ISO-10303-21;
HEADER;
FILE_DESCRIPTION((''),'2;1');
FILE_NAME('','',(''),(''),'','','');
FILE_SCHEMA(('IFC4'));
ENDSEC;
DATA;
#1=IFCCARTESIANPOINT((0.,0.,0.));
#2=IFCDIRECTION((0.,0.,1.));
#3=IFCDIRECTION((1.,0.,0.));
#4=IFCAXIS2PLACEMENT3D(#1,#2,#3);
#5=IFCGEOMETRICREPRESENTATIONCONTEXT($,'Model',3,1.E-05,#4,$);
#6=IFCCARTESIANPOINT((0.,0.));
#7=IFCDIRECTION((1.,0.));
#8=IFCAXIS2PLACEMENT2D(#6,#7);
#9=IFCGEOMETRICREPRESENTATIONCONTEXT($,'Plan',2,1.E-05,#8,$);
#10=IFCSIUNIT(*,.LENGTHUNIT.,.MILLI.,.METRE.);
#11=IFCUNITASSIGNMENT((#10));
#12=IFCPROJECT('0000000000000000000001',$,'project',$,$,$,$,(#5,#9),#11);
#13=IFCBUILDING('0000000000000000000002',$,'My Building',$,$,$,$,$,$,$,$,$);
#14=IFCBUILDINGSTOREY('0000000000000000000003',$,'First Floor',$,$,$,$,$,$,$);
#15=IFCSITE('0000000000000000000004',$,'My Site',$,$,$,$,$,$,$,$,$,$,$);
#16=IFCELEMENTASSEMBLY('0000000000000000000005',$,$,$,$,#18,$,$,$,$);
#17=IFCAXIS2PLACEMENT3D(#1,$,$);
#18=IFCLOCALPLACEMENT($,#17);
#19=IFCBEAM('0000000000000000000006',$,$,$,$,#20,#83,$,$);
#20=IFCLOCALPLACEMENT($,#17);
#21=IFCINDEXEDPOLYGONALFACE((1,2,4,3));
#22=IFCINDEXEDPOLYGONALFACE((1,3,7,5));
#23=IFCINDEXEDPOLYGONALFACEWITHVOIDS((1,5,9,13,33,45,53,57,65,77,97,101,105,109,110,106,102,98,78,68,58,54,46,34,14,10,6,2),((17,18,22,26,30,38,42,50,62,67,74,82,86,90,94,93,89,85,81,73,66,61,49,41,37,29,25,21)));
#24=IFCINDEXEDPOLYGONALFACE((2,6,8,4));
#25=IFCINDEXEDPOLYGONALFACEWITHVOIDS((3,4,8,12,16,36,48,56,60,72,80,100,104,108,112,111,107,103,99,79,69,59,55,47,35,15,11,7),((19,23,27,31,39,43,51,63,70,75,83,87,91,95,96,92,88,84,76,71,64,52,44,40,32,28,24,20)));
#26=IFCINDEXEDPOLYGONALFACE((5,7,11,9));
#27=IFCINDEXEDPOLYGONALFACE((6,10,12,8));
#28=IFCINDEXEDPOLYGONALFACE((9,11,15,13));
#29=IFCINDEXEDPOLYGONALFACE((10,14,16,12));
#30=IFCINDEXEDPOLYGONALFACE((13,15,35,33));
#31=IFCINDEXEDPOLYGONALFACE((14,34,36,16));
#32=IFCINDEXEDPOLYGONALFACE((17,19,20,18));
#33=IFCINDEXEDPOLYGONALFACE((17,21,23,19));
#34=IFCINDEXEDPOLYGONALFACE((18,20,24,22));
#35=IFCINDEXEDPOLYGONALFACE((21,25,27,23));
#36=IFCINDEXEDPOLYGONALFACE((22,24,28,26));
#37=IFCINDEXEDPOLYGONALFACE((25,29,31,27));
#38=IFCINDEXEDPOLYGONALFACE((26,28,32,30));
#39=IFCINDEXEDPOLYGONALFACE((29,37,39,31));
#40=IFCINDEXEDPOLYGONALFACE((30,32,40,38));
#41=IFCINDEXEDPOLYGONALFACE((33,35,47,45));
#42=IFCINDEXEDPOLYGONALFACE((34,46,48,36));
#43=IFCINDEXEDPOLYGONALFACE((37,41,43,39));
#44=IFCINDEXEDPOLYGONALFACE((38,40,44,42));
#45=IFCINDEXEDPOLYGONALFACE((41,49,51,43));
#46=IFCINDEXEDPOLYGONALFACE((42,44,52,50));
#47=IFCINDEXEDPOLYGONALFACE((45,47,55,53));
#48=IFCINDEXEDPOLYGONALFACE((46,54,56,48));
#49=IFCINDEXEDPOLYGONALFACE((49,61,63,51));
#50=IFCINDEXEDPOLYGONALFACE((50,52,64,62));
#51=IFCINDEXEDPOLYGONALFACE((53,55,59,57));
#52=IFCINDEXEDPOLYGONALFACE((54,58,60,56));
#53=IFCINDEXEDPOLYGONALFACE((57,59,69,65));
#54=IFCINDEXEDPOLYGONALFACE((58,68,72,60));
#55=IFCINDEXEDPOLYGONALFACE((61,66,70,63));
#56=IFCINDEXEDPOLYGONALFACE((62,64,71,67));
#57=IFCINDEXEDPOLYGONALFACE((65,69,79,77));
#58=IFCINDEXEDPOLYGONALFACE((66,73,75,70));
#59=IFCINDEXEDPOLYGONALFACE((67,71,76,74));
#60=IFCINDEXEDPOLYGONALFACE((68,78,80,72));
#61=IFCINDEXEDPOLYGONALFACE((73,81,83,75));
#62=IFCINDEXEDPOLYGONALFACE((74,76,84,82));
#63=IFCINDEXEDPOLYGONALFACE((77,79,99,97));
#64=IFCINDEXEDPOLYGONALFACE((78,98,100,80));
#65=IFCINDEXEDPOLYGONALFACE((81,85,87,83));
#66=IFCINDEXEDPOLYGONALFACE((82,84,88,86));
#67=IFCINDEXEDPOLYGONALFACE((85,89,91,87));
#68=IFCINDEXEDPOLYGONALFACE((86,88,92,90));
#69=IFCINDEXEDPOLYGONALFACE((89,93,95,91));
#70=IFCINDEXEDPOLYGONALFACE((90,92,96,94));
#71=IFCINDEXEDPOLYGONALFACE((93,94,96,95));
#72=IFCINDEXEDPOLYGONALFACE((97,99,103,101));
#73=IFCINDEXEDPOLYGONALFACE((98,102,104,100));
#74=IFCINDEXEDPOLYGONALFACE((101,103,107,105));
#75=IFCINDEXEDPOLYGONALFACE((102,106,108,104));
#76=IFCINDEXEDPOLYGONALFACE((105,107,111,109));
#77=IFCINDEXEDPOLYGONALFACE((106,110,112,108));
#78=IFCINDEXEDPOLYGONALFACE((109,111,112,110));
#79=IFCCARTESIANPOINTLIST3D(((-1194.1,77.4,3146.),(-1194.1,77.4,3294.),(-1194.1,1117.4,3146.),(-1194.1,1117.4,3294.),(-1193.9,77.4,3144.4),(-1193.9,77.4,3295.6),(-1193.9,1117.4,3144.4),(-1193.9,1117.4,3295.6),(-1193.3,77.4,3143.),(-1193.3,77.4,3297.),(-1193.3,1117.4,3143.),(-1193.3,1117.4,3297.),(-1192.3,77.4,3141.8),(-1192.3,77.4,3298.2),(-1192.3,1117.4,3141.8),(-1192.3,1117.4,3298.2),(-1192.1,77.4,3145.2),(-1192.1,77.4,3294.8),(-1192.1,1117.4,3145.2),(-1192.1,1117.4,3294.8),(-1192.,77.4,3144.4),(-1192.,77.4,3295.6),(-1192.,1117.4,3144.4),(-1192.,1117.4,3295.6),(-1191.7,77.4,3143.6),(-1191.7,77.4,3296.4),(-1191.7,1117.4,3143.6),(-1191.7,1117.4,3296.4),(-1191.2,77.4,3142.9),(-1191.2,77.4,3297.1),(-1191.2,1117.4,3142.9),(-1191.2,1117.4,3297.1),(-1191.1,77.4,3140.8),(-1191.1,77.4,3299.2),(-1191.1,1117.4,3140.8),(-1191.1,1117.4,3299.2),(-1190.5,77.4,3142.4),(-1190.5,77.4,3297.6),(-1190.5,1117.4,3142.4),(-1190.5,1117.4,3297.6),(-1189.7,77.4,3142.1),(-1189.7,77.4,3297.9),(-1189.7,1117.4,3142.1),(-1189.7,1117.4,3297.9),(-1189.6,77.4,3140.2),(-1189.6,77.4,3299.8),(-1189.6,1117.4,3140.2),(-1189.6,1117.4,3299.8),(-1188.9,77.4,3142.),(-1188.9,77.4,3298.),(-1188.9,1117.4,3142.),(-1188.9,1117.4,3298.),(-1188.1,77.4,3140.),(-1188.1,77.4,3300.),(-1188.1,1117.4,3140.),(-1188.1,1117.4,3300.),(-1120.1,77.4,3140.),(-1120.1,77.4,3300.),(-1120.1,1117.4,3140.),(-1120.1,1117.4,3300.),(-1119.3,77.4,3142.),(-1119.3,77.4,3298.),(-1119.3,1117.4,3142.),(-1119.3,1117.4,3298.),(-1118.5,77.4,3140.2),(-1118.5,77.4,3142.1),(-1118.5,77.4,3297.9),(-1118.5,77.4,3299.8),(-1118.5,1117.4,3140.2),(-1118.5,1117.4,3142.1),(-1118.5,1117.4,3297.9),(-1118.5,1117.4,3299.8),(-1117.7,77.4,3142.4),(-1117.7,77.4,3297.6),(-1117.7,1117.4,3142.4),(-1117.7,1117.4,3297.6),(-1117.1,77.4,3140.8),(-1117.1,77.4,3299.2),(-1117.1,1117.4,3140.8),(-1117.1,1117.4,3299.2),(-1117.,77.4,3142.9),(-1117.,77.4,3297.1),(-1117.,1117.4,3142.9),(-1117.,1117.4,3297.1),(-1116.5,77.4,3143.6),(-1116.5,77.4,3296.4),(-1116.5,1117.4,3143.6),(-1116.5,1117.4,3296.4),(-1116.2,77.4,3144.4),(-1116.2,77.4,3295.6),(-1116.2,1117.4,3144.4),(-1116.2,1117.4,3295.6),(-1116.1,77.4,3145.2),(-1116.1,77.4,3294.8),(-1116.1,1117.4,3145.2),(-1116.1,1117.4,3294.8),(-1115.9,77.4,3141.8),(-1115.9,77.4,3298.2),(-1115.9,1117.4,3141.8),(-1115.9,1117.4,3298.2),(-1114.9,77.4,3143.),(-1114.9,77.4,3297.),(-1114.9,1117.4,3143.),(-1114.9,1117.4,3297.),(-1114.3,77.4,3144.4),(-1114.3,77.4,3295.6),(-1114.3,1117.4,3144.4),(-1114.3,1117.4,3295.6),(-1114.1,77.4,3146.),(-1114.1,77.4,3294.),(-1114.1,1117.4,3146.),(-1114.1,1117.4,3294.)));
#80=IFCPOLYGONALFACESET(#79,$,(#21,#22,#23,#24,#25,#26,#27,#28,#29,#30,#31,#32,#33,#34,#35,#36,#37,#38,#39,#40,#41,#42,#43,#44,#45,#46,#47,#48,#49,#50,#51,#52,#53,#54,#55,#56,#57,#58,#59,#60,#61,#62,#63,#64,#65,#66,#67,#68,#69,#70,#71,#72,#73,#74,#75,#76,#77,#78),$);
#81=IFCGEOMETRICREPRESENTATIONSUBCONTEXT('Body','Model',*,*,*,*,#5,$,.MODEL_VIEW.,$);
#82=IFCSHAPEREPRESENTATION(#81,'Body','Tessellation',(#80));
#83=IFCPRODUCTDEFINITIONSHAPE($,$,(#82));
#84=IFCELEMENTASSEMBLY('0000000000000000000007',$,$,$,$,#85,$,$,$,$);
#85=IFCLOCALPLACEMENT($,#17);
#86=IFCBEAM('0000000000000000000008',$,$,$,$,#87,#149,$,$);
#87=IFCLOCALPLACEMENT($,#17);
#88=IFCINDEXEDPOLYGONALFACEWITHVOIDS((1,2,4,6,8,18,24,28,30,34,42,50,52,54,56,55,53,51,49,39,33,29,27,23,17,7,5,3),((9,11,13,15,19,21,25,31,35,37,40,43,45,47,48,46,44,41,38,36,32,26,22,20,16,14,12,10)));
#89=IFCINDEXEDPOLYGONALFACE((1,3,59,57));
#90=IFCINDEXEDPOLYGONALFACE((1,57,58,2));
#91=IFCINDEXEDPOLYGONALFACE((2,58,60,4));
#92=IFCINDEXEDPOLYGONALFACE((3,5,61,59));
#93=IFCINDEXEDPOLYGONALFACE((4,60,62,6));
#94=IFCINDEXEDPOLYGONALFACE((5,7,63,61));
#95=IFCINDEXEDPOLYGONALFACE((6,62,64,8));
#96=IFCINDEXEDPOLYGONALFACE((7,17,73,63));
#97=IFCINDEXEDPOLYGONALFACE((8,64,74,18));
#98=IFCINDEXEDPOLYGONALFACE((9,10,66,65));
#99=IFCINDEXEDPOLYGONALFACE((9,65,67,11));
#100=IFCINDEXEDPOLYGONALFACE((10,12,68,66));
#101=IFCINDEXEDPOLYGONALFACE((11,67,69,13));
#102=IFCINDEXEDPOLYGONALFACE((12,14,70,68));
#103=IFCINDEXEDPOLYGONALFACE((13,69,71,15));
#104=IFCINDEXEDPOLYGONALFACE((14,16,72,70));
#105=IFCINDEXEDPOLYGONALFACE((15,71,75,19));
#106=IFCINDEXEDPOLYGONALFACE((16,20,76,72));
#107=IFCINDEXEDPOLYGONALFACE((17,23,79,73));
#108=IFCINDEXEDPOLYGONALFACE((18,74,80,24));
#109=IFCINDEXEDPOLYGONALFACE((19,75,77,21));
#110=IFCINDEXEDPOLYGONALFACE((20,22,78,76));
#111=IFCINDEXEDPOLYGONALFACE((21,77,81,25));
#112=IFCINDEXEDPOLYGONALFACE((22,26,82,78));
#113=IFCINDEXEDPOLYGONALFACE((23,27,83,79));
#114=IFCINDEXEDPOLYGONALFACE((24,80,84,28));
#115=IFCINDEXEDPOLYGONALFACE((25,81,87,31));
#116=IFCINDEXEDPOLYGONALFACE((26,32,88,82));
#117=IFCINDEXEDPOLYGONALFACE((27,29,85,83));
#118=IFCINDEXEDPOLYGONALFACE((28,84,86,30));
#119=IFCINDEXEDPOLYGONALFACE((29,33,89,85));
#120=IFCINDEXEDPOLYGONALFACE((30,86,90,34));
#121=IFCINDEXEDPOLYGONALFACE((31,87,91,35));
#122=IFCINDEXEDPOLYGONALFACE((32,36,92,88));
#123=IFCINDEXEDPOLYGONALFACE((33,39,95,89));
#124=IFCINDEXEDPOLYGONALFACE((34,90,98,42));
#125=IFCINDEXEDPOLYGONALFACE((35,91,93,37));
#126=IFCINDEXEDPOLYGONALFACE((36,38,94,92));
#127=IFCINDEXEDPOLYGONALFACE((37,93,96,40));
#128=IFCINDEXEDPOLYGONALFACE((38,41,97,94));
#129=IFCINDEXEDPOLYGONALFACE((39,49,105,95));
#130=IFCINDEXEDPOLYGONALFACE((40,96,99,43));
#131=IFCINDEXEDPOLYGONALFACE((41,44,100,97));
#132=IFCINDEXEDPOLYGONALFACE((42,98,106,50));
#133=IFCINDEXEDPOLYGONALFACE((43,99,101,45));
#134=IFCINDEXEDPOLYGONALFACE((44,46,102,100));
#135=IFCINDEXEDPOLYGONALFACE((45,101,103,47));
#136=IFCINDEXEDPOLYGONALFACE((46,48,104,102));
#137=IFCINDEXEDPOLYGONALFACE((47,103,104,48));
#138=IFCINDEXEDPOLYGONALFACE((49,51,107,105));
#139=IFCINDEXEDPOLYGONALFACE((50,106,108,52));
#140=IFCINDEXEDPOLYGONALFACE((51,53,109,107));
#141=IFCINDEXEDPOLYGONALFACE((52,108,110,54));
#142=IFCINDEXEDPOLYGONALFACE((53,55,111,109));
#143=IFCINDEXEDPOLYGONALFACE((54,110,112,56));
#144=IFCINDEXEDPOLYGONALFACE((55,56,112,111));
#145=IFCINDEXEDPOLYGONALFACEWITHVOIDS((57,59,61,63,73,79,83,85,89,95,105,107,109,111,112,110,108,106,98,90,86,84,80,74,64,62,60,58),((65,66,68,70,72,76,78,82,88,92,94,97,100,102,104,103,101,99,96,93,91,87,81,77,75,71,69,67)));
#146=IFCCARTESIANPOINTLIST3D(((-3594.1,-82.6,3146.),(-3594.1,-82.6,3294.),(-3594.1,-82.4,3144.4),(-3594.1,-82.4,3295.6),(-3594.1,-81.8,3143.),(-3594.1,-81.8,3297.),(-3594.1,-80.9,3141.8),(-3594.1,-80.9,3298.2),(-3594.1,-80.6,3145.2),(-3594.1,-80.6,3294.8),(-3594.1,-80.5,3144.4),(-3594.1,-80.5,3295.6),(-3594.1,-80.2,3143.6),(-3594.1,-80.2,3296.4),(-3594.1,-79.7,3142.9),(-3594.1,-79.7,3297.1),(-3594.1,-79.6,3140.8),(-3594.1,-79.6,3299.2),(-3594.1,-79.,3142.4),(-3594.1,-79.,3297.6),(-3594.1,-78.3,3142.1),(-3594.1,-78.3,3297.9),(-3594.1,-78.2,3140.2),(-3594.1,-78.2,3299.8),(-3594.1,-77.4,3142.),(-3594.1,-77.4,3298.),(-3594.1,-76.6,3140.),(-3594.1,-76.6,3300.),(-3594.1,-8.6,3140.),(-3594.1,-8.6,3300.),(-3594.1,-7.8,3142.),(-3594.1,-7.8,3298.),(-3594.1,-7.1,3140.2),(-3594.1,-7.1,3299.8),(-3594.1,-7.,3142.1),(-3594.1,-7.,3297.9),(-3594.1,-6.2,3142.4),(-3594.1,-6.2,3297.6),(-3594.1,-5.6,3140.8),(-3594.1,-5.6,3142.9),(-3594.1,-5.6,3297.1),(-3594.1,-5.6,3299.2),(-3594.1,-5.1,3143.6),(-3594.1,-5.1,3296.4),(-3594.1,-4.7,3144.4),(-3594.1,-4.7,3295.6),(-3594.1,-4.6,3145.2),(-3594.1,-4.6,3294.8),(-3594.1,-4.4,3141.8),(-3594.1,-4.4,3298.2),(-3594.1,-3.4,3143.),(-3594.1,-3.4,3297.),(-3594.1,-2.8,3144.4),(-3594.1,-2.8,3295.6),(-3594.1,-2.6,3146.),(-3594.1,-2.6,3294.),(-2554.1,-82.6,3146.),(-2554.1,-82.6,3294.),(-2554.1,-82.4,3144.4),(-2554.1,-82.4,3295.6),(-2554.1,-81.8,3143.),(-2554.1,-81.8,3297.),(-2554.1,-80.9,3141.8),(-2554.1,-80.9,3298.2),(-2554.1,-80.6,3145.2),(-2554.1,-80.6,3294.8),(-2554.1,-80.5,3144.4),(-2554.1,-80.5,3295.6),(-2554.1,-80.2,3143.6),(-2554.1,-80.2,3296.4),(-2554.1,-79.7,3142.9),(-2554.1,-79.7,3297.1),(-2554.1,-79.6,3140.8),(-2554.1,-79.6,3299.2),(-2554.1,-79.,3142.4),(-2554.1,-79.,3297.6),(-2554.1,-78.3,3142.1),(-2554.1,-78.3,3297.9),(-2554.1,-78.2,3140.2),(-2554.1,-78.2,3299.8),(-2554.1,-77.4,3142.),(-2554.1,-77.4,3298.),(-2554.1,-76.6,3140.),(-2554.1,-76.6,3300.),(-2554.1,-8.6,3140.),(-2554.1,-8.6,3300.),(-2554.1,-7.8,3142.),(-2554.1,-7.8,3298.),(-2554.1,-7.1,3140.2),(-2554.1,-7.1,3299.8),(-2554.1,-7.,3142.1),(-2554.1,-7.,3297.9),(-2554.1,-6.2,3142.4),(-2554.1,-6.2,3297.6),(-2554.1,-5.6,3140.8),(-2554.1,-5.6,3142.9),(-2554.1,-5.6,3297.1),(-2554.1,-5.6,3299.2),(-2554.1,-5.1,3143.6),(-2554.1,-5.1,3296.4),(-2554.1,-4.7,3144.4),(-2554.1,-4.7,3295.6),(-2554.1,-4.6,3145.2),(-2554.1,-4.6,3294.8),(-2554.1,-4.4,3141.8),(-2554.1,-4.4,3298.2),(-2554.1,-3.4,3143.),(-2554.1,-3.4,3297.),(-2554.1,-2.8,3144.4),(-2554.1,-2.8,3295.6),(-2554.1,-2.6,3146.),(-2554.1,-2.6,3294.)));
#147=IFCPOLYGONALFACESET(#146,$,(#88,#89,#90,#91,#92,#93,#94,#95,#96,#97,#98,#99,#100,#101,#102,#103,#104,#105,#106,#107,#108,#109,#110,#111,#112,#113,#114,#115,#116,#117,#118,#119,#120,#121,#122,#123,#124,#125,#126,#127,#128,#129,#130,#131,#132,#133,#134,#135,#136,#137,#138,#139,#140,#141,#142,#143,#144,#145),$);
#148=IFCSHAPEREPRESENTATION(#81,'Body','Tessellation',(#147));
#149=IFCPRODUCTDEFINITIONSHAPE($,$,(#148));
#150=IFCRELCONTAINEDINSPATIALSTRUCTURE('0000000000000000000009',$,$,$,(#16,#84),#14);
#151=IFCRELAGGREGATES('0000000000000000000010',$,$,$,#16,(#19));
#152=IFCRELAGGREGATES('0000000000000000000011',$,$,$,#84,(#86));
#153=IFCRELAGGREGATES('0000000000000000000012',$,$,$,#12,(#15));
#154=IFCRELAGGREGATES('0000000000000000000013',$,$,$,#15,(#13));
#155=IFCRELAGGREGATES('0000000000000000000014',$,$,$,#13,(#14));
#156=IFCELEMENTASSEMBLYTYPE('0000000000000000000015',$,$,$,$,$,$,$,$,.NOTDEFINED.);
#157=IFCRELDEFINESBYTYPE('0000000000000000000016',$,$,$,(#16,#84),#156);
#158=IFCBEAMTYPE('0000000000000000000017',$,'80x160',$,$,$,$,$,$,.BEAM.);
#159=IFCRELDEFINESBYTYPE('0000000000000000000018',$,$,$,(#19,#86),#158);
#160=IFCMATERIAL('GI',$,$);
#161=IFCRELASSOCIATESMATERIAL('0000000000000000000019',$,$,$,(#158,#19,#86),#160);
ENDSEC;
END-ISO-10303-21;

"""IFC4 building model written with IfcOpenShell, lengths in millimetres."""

from ifc_helpers import new_model, si_unit, frame, origin_with_axes, origin_2d_with_axis, place, context, subcontext, project, spatial, hollow_rectangle, extrude, material, material_profile, profile_set, profile_usage, type_object, element, aggregate, save


model = new_model("IFC4")

# Units and contexts
model_context = context("Model", 3, precision=1e-05, world=origin_with_axes())
plan_context = context("Plan", 2, precision=1e-05, world=origin_2d_with_axis())
body_context = subcontext(model_context, "Body", "Model", "MODEL_VIEW")
ifc_project = project(units=[si_unit("LENGTHUNIT", "METRE", prefix="MILLI")], contexts=[model_context, plan_context])

# Site, building, storey
site = spatial("IfcSite", under=ifc_project, Name="My Site")
building = spatial("IfcBuilding", under=site, Name="My Building")
storey = spatial("IfcBuildingStorey", under=building, Name="First Floor")

# Element assemblies, beams
element_assembly_type = type_object("IfcElementAssemblyType", PredefinedType="NOTDEFINED")
ifc_material = material(Name="GI")
ifc_material_profile = material_profile(ifc_material, hollow_rectangle(XDim=80.0, YDim=160.0, WallThickness=2.0, InnerFilletRadius=3.2, OuterFilletRadius=6.0))
ifc_profile_set = profile_set([ifc_material_profile], Name="80x160 GI Rectangular Hollow")
beam_type = type_object("IfcBeamType", Name="80x160", PredefinedType="BEAM", material=ifc_profile_set)
assembly_1_placement = place(None, frame((-1154.1, -2.6, 3220.0), z_axis=(0.0, 1.0, 0.0), x_axis=(1.0, 0.0, 0.0)))
assembly_1 = element("IfcElementAssembly", 1, at=assembly_1_placement, inside=storey, type_object=element_assembly_type)
ifc_profile_usage_1 = profile_usage(ifc_profile_set)
beam_1_placement = place(assembly_1_placement, frame((0.0, 0.0, 80.0), z_axis=(0.0, 0.0, 1.0), x_axis=(1.0, 0.0, 0.0)))
beam_1 = element("IfcBeam", 2, at=beam_1_placement, type_object=beam_type, material=ifc_profile_usage_1, context=body_context, shape_type="SweptSolid", body=[
    extrude(hollow_rectangle(XDim=80.0, YDim=160.0, WallThickness=2.0, InnerFilletRadius=3.2, OuterFilletRadius=6.0), origin_with_axes(), (0.0, 0.0, 1.0), 1040.0),
])
aggregate(assembly_1, [beam_1])
assembly_2_placement = place(None, frame((-3674.1, -42.6, 3220.0), z_axis=(1.0, 0.0, 0.0), x_axis=(0.0, 1.0, 0.0)))
assembly_2 = element("IfcElementAssembly", 3, at=assembly_2_placement, inside=storey, type_object=element_assembly_type)
ifc_profile_usage_2 = profile_usage(ifc_profile_set)
beam_2_placement = place(assembly_2_placement, frame((0.0, 0.0, 80.0), z_axis=(0.0, 0.0, 1.0), x_axis=(1.0, 0.0, 0.0)))
beam_2 = element("IfcBeam", 4, at=beam_2_placement, type_object=beam_type, material=ifc_profile_usage_2, context=body_context, shape_type="SweptSolid", body=[
    extrude(hollow_rectangle(XDim=80.0, YDim=160.0, WallThickness=2.0, InnerFilletRadius=3.2, OuterFilletRadius=6.0), origin_with_axes(), (0.0, 0.0, 1.0), 1040.0),
])
aggregate(assembly_2, [beam_2])

save(model, "model.ifc")
